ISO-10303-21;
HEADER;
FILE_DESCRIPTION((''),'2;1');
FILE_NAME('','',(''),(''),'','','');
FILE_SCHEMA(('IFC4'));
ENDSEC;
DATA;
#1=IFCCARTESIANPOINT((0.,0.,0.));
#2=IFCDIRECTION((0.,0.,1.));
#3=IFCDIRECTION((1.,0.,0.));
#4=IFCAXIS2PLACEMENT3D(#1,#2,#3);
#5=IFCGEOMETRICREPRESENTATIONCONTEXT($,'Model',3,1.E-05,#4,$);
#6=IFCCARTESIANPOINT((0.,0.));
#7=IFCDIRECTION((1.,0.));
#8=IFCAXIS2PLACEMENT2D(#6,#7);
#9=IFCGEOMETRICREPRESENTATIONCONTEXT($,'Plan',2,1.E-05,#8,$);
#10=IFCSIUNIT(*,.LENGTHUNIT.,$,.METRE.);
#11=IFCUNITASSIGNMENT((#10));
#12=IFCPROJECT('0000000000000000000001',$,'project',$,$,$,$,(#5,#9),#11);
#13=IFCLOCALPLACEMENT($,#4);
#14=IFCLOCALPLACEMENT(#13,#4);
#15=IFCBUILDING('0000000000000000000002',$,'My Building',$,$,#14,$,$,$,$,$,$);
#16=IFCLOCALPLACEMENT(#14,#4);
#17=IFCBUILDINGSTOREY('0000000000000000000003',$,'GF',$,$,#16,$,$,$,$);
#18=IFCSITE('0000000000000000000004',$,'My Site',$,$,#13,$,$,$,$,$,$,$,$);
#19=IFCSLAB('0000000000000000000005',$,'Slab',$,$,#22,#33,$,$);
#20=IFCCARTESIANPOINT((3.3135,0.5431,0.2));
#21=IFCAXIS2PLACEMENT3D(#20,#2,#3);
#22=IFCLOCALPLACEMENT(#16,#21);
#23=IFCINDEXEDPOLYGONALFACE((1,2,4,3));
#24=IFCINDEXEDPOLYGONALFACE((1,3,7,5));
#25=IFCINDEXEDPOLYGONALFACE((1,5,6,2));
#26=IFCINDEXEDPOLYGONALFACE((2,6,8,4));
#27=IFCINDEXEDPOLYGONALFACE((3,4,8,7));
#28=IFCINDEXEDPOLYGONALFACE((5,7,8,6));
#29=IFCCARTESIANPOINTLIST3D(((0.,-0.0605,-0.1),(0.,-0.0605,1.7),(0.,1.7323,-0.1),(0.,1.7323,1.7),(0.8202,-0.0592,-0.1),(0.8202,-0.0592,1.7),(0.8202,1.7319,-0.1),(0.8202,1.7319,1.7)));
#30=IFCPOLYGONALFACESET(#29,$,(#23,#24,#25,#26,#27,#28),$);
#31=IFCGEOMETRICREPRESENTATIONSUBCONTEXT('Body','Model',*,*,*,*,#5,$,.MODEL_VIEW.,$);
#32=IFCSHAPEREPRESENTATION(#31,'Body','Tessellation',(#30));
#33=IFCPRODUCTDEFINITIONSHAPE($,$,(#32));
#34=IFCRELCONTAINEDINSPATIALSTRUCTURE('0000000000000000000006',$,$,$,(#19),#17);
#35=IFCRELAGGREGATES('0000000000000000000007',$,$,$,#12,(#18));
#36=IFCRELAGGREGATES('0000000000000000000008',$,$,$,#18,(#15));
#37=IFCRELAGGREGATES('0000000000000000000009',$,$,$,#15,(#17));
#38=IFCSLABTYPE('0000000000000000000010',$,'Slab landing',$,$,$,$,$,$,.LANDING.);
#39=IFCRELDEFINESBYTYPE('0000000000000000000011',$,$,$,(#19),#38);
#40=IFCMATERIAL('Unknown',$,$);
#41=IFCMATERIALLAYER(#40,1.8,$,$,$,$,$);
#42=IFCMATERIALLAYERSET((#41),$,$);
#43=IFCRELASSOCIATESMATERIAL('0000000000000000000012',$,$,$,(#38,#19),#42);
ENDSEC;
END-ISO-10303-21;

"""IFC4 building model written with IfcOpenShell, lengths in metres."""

from ifc_helpers import new_model, si_unit, frame, origin_with_axes, origin_2d_with_axis, place, context, subcontext, project, spatial, indexed_curve, outline, extrude, material, layer, layer_set, layer_usage, type_object, element, save


model = new_model("IFC4")

# Units and contexts
model_context = context("Model", 3, precision=1e-05, world=origin_with_axes())
plan_context = context("Plan", 2, precision=1e-05, world=origin_2d_with_axis())
body_context_1 = subcontext(model_context, "Body", "Model", "MODEL_VIEW")
ifc_project = project(units=[si_unit("LENGTHUNIT", "METRE")], contexts=[model_context, plan_context])

# Site, building, storey
site_placement = place(None, origin_with_axes())
site = spatial("IfcSite", under=ifc_project, at=site_placement, Name="My Site")
building_placement = place(site_placement, origin_with_axes())
building = spatial("IfcBuilding", under=site, at=building_placement, Name="My Building")
storey_placement = place(building_placement, origin_with_axes())
storey = spatial("IfcBuildingStorey", under=building, at=storey_placement, Name="GF")

# Shared definitions
ifc_material = material(Name="Unknown")

# Slab
ifc_layer_1 = layer(ifc_material, 1.8)
ifc_layer_set_1 = layer_set([ifc_layer_1])
ifc_layer_usage_1 = layer_usage(ifc_layer_set_1, "AXIS3", "POSITIVE", -0.1)
slab_type_1 = type_object("IfcSlabType", Name="Slab landing", PredefinedType="LANDING", material=ifc_layer_set_1)
slab_1_placement = place(storey_placement, frame((3.3135, 0.5431, 0.2), z_axis=(0.0, 0.0, 1.0), x_axis=(1.0, 0.0, 0.0)))
element("IfcSlab", 1, at=slab_1_placement, inside=storey, type_object=slab_type_1, material=ifc_layer_usage_1, Name="Slab", context=body_context_1, shape_type="SweptSolid", body=[
    extrude(outline(indexed_curve([(0.0, -0.0605), (0.0, 1.7323), (0.8202, 1.7319), (0.8202, -0.0592), (0.0, -0.0605)])), frame((0.0, 0.0, -0.1), z_axis=(0.0, 0.0, 1.0), x_axis=(1.0, 0.0, 0.0)), (0.0, 0.0, 1.0), 1.8),
])

save(model, "model.ifc")
